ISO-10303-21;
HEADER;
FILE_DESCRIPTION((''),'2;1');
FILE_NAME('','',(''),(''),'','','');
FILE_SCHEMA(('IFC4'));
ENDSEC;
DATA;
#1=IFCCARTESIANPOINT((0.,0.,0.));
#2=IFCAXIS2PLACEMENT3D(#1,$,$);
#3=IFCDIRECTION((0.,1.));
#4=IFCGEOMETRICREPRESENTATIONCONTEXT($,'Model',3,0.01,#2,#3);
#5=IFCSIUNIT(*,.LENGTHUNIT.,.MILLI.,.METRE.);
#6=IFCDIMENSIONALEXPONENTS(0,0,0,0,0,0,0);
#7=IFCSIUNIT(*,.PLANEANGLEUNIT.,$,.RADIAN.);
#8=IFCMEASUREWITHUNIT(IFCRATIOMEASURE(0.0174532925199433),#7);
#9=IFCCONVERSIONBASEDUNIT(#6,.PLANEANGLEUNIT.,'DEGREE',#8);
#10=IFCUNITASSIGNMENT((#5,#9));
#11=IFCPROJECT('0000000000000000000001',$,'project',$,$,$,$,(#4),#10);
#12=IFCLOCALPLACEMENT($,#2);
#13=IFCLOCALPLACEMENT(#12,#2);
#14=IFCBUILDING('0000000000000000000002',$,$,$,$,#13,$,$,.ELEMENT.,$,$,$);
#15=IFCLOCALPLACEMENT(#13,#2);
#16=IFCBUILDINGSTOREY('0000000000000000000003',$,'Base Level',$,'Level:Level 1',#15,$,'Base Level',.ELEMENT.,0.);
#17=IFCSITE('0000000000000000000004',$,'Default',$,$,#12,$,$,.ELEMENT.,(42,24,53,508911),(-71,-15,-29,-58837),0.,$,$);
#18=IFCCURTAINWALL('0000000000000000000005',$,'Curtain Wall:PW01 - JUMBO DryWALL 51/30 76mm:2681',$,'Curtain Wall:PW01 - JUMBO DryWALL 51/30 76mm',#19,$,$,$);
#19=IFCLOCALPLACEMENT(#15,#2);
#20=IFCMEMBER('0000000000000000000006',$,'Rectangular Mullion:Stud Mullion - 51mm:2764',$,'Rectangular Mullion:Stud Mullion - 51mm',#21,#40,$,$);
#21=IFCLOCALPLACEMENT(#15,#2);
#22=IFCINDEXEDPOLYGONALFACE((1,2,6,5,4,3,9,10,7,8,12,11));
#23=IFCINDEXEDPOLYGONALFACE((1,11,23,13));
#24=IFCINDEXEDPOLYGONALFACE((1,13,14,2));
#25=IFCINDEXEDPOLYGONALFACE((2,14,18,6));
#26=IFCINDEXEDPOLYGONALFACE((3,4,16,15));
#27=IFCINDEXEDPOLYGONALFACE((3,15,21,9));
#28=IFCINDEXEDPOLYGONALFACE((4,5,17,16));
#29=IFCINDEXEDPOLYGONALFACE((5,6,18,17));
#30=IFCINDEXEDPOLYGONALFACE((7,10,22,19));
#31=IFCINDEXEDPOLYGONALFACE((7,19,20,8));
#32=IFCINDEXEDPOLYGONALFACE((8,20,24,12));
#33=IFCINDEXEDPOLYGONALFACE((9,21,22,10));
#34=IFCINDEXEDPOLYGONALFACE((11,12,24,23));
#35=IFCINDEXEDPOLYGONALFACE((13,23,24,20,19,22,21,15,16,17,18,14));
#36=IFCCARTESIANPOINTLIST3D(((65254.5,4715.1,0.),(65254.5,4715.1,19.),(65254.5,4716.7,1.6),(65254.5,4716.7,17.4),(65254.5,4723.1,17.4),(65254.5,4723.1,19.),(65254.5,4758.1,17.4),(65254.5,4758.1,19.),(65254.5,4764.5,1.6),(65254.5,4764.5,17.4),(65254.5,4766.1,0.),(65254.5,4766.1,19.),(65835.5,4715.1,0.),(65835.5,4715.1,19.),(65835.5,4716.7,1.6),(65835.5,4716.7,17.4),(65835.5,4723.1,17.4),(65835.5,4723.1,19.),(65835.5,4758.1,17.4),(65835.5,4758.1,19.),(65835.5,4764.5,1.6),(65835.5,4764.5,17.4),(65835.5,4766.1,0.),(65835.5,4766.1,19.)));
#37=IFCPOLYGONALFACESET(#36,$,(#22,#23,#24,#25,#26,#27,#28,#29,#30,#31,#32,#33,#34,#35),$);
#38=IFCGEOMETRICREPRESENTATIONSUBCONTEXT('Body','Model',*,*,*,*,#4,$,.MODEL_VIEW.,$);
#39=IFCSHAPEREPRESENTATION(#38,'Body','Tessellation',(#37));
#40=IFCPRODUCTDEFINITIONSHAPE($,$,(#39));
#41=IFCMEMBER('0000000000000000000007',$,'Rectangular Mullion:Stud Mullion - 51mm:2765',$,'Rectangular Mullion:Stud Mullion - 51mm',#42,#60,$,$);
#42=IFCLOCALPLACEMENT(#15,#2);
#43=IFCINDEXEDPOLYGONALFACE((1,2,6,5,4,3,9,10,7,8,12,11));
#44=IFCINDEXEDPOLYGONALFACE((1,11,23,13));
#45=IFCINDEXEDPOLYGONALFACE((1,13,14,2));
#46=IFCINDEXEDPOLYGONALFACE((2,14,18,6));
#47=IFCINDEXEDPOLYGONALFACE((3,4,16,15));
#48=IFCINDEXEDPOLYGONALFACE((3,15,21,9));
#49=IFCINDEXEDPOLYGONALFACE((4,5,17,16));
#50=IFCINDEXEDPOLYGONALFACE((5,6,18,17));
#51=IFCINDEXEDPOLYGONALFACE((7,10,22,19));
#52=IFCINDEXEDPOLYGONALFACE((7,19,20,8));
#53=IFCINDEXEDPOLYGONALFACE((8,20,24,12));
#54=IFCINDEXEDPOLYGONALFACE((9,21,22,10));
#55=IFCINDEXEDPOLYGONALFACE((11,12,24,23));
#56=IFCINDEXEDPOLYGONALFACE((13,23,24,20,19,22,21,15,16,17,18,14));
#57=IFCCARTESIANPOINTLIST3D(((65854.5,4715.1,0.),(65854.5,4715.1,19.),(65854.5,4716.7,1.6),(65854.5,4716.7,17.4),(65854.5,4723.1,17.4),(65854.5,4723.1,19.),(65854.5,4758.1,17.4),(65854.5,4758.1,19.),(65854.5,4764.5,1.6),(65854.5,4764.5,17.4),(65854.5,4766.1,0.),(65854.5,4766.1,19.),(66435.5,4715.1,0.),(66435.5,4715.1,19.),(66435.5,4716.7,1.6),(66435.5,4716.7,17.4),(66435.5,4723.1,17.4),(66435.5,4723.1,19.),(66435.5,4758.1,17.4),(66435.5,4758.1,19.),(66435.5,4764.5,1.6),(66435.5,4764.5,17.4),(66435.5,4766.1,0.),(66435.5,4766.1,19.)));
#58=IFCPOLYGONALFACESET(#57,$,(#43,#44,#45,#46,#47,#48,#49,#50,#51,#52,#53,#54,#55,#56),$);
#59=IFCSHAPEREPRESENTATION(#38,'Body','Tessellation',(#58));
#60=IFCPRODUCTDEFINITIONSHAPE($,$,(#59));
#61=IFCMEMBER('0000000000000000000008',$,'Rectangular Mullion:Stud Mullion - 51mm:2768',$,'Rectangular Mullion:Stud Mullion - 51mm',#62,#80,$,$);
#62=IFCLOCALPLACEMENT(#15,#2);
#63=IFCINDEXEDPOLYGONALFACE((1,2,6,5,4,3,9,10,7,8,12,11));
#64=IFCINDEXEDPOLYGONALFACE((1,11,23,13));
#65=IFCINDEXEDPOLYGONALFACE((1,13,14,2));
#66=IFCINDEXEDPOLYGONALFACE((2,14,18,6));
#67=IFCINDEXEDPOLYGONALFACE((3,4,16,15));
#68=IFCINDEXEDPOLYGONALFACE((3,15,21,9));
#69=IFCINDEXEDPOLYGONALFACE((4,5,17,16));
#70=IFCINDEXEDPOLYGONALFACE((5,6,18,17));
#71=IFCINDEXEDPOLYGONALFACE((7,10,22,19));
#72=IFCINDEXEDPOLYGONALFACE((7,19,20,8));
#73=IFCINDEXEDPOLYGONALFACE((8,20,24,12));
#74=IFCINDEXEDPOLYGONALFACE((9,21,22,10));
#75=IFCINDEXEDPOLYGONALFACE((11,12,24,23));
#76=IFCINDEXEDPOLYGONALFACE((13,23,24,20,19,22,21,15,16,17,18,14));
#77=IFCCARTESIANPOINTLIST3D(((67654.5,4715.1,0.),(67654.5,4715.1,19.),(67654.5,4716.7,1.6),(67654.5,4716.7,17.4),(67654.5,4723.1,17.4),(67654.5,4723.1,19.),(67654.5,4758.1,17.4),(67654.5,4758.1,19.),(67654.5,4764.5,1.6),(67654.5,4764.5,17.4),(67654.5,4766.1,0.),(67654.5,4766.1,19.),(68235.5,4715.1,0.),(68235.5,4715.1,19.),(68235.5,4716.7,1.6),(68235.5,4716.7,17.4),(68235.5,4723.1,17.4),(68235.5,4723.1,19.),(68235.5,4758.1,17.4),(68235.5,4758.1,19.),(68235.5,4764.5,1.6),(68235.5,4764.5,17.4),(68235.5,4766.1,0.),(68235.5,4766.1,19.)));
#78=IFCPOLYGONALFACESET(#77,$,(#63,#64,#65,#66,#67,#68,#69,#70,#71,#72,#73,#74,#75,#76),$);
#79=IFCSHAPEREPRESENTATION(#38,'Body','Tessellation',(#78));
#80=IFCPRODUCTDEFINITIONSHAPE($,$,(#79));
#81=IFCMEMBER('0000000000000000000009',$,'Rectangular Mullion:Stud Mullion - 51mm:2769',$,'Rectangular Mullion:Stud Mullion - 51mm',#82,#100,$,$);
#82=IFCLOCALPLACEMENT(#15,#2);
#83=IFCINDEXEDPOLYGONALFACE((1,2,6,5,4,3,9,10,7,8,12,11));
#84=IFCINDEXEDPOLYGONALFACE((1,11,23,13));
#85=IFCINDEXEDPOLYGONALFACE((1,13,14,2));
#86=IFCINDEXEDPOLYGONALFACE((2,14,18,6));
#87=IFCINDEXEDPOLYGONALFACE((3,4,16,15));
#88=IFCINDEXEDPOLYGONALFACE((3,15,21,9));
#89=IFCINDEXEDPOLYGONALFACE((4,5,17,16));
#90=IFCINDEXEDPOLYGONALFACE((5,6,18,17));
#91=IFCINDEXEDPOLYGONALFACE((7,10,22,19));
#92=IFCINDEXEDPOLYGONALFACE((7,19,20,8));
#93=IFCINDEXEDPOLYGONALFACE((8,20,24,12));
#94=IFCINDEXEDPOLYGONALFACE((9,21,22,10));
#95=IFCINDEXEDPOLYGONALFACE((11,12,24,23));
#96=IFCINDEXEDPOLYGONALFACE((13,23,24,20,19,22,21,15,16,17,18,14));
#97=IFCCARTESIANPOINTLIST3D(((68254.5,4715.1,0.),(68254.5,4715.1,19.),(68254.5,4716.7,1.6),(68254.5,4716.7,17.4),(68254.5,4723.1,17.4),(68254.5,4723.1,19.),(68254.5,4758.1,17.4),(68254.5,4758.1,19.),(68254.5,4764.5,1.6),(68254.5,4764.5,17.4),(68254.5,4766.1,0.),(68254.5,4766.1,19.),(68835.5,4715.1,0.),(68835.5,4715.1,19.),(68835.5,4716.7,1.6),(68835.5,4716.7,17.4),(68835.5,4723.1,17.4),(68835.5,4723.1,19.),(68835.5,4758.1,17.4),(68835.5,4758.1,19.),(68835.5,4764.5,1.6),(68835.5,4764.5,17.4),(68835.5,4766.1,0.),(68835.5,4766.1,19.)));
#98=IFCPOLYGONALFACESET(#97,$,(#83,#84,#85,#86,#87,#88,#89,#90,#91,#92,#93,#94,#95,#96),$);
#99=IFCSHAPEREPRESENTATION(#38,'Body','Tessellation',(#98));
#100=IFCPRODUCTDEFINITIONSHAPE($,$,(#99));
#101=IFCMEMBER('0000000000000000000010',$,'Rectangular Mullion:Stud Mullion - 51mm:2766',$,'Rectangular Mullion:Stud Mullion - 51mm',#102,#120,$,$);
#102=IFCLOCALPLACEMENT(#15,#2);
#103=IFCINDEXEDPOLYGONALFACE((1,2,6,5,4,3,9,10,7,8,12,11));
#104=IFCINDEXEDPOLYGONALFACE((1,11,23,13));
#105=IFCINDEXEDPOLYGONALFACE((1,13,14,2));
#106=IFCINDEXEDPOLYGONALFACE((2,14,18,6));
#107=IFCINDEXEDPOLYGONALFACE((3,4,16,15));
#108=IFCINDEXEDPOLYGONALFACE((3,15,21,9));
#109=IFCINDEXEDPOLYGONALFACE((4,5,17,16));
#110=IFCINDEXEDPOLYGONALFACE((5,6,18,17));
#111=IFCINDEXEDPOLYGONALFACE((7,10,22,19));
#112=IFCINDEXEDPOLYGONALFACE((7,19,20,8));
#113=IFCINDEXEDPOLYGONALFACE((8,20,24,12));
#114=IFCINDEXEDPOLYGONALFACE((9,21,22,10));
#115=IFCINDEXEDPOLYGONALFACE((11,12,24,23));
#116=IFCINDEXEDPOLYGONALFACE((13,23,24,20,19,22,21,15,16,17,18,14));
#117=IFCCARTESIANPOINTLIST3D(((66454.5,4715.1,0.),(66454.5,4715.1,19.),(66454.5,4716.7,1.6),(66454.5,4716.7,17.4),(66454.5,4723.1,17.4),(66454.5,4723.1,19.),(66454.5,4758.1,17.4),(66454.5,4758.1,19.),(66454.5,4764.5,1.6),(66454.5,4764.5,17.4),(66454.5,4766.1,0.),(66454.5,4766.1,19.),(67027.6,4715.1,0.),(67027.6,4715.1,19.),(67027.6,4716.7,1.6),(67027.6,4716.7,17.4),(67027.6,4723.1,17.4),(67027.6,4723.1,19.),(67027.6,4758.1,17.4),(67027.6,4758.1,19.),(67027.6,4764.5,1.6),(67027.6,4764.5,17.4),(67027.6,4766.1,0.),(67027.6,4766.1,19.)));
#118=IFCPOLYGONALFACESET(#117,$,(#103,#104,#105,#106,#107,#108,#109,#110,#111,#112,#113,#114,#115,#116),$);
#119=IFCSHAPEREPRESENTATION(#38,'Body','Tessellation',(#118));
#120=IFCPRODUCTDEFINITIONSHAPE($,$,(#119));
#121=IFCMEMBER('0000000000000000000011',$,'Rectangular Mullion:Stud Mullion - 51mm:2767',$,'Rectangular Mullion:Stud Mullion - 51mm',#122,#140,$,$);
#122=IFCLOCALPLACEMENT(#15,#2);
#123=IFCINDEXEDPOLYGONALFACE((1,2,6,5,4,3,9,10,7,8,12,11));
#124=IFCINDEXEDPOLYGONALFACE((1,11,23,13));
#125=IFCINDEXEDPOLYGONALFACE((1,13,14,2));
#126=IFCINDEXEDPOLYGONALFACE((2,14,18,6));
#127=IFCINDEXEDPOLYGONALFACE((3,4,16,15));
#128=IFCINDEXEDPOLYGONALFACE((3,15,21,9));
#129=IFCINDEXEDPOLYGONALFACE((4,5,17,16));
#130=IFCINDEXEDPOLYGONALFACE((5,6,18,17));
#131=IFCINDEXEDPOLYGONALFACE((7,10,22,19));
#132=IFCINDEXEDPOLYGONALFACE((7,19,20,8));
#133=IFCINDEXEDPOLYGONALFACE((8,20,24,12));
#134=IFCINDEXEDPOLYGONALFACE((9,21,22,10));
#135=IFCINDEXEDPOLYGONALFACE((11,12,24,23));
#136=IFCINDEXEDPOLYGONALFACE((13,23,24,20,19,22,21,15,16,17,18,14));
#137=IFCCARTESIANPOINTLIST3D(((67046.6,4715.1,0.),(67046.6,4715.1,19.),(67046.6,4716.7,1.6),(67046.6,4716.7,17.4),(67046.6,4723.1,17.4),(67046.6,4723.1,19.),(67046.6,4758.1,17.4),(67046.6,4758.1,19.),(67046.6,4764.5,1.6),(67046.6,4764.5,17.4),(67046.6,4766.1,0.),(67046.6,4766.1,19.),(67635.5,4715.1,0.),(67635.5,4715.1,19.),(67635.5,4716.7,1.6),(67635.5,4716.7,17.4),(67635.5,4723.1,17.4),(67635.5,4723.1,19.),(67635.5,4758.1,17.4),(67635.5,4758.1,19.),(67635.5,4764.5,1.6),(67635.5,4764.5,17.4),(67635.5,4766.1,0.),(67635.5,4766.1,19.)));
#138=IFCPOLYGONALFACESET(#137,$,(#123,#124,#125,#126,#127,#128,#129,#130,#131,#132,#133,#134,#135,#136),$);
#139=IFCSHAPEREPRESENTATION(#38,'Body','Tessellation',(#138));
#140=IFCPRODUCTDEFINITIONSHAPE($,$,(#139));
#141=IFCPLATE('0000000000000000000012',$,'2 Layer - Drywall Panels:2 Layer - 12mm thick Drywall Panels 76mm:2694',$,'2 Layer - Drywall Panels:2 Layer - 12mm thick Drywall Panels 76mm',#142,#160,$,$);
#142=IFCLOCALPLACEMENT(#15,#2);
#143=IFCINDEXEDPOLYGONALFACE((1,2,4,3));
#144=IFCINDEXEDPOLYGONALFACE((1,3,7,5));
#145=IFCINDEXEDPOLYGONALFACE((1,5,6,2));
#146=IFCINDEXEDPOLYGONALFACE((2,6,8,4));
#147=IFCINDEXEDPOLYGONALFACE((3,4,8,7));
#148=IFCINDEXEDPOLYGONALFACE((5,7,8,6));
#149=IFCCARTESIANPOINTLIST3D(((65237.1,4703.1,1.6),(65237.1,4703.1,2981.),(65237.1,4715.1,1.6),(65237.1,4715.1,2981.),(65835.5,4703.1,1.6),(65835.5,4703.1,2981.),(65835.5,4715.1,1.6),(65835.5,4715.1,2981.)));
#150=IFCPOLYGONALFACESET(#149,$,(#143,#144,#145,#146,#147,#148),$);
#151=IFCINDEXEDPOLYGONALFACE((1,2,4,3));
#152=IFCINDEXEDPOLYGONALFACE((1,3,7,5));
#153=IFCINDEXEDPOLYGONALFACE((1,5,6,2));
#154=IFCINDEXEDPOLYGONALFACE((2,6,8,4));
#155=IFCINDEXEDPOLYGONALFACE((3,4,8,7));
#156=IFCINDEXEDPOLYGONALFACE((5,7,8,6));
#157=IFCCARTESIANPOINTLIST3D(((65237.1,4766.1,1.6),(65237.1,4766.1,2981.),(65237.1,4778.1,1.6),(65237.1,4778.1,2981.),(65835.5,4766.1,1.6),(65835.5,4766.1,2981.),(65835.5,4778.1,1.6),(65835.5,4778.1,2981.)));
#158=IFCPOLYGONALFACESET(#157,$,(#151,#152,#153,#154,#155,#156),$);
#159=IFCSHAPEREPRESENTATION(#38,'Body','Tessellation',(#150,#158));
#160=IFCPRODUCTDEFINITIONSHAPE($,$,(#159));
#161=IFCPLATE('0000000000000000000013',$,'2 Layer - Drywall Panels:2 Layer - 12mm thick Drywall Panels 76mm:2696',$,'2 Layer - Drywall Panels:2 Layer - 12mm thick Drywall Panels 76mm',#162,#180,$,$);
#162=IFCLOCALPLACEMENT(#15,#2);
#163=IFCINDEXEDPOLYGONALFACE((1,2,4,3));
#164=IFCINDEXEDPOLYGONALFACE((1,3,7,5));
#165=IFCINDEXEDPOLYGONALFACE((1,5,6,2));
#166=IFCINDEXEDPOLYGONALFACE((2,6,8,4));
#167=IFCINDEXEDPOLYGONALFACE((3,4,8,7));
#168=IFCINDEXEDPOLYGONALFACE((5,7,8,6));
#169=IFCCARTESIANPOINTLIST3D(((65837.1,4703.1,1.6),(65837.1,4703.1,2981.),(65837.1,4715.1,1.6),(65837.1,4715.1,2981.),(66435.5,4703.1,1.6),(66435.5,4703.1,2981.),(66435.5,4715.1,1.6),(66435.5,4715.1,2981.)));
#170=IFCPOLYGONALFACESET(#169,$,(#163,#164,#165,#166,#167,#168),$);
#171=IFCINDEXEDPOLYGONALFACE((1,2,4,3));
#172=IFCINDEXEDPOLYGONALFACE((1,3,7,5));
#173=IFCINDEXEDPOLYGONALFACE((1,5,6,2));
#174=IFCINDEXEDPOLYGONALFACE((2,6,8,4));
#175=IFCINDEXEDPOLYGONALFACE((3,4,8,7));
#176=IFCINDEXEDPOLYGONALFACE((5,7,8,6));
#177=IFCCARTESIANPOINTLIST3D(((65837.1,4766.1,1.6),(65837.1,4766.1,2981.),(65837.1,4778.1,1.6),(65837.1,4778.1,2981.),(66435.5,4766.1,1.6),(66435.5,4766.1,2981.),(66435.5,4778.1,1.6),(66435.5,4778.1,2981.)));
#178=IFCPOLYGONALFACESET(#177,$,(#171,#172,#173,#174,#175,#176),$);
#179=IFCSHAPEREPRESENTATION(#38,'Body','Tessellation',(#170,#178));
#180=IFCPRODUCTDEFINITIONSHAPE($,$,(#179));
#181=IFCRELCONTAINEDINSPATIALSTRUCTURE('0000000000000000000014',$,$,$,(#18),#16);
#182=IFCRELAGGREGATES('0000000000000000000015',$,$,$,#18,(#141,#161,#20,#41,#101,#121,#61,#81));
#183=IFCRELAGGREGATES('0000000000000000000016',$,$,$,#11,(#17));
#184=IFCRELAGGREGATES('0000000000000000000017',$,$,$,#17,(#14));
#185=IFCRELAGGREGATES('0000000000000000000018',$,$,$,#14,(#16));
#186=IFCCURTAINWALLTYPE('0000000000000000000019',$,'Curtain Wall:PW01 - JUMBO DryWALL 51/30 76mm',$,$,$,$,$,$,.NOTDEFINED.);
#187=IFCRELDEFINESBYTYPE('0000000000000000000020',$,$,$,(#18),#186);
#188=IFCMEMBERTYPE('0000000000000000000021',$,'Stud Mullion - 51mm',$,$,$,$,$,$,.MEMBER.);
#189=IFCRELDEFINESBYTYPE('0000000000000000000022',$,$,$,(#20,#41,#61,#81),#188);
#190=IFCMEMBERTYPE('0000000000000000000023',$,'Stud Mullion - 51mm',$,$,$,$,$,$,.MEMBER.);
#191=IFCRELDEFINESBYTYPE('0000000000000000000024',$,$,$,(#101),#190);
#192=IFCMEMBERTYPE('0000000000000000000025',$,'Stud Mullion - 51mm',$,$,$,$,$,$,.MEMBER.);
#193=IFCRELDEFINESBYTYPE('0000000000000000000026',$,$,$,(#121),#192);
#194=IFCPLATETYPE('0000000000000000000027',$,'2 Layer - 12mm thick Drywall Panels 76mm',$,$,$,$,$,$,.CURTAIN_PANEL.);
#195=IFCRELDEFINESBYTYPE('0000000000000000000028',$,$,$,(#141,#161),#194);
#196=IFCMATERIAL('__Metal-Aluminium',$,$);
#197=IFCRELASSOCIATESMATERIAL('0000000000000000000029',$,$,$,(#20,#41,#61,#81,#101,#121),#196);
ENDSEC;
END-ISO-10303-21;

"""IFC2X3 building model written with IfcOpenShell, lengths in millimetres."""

from ifc_helpers import new_model, entity, si_unit, converted_unit, direction, frame, frame_2d, origin, origin_2d_with_axis, place, context, subcontext, project, spatial, polyline, rectangle, outline, extrude, source, transform, mapped, material, type_object, type_shapes, element, aggregate, save


model = new_model("IFC2X3")

# Units and contexts
model_context = context("Model", 3, precision=0.01, world=origin(), true_north=direction((0.0, 1.0)))
body_context = subcontext(model_context, "Body", "Model", "MODEL_VIEW")
ifc_project = project(units=[si_unit("LENGTHUNIT", "METRE", prefix="MILLI"), converted_unit("PLANEANGLEUNIT", "DEGREE", entity("IfcRatioMeasure", 0.0174532925199433), si_unit("PLANEANGLEUNIT", "RADIAN"), dimensions=[0, 0, 0, 0, 0, 0, 0])], contexts=[model_context])

# Site, building, storey
site_placement = place(None, origin())
site = spatial("IfcSite", under=ifc_project, at=site_placement, Name="Default", CompositionType="ELEMENT", RefLatitude=(42, 24, 53, 508911), RefLongitude=(-71, -15, -29, -58837), RefElevation=0.0)
building_placement = place(site_placement, origin())
building = spatial("IfcBuilding", under=site, at=building_placement, CompositionType="ELEMENT")
storey_placement = place(building_placement, origin())
storey = spatial("IfcBuildingStorey", under=building, at=storey_placement, Name="Base Level", ObjectType="Level:Level 1", LongName="Base Level", CompositionType="ELEMENT", Elevation=0.0)

# Curtain wall, members, plates
curtain_wall_type = type_object("IfcCurtainWallType", Name="Curtain Wall:PW01 - JUMBO DryWALL 51/30 76mm", PredefinedType="NOTDEFINED")
curtain_wall_placement = place(building_placement, origin())
curtain_wall = element("IfcCurtainWall", 1, at=curtain_wall_placement, inside=storey, type_object=curtain_wall_type, Name="Curtain Wall:PW01 - JUMBO DryWALL 51/30 76mm:2681", ObjectType="Curtain Wall:PW01 - JUMBO DryWALL 51/30 76mm")
ifc_material = material(Name="__Metal-Aluminium")
member_type_1 = type_object("IfcMemberType", Name="Stud Mullion - 51mm", PredefinedType="MEMBER")
shared_shape_1 = source(origin(), body_context, "Body", "SweptSolid", [
    extrude(outline(polyline([(17.5, -6.6), (25.5, -6.6), (25.5, 12.4), (-25.5, 12.4), (-25.5, -6.6), (-17.5, -6.6), (-17.5, -5.0), (-23.9, -5.0), (-23.9, 10.8), (23.9, 10.8), (23.9, -5.0), (17.5, -5.0), (17.5, -6.6)])), frame((-12.4, 0.0, -581.0), z_axis=(0.0, 0.0, 1.0), x_axis=(0.0, -1.0, 0.0)), (0.0, 0.0, 1.0), 581.0),
])
type_shapes(member_type_1, [shared_shape_1])
member_1_placement = place(building_placement, frame((65254.5, 4740.6, 0.0), z_axis=(-1.0, 0.0, 0.0), x_axis=(0.0, 0.0, -1.0)))
member_1 = element("IfcMember", 2, at=member_1_placement, type_object=member_type_1, material=ifc_material, Name="Rectangular Mullion:Stud Mullion - 51mm:2764", ObjectType="Rectangular Mullion:Stud Mullion - 51mm", context=body_context, shape_type="MappedRepresentation", body=[
    mapped(shared_shape_1, transform((0.0, 0.0, 0.0), scale=1.0)),
])
member_2_placement = place(building_placement, frame((65854.5, 4740.6, 0.0), z_axis=(-1.0, 0.0, 0.0), x_axis=(0.0, 0.0, -1.0)))
member_2 = element("IfcMember", 3, at=member_2_placement, type_object=member_type_1, material=ifc_material, Name="Rectangular Mullion:Stud Mullion - 51mm:2765", ObjectType="Rectangular Mullion:Stud Mullion - 51mm", context=body_context, shape_type="MappedRepresentation", body=[
    mapped(shared_shape_1, transform((0.0, 0.0, 0.0), scale=1.0)),
])
member_3_placement = place(building_placement, frame((67654.5, 4740.6, 0.0), z_axis=(-1.0, 0.0, 0.0), x_axis=(0.0, 0.0, -1.0)))
member_3 = element("IfcMember", 4, at=member_3_placement, type_object=member_type_1, material=ifc_material, Name="Rectangular Mullion:Stud Mullion - 51mm:2768", ObjectType="Rectangular Mullion:Stud Mullion - 51mm", context=body_context, shape_type="MappedRepresentation", body=[
    mapped(shared_shape_1, transform((0.0, 0.0, 0.0), scale=1.0)),
])
member_4_placement = place(building_placement, frame((68254.5, 4740.6, 0.0), z_axis=(-1.0, 0.0, 0.0), x_axis=(0.0, 0.0, -1.0)))
member_4 = element("IfcMember", 5, at=member_4_placement, type_object=member_type_1, material=ifc_material, Name="Rectangular Mullion:Stud Mullion - 51mm:2769", ObjectType="Rectangular Mullion:Stud Mullion - 51mm", context=body_context, shape_type="MappedRepresentation", body=[
    mapped(shared_shape_1, transform((0.0, 0.0, 0.0), scale=1.0)),
])
member_type_2 = type_object("IfcMemberType", Name="Stud Mullion - 51mm", PredefinedType="MEMBER")
shared_shape_2 = source(origin(), body_context, "Body", "SweptSolid", [
    extrude(outline(polyline([(17.5, -6.6), (25.5, -6.6), (25.5, 12.4), (-25.5, 12.4), (-25.5, -6.6), (-17.5, -6.6), (-17.5, -5.0), (-23.9, -5.0), (-23.9, 10.8), (23.9, 10.8), (23.9, -5.0), (17.5, -5.0), (17.5, -6.6)])), frame((-12.4, 0.0, -573.1), z_axis=(0.0, 0.0, 1.0), x_axis=(0.0, -1.0, 0.0)), (0.0, 0.0, 1.0), 573.1),
])
type_shapes(member_type_2, [shared_shape_2])
member_5_placement = place(building_placement, frame((66454.5, 4740.6, 0.0), z_axis=(-1.0, 0.0, 0.0), x_axis=(0.0, 0.0, -1.0)))
member_5 = element("IfcMember", 6, at=member_5_placement, type_object=member_type_2, material=ifc_material, Name="Rectangular Mullion:Stud Mullion - 51mm:2766", ObjectType="Rectangular Mullion:Stud Mullion - 51mm", context=body_context, shape_type="MappedRepresentation", body=[
    mapped(shared_shape_2, transform((0.0, 0.0, 0.0), scale=1.0)),
])
member_type_3 = type_object("IfcMemberType", Name="Stud Mullion - 51mm", PredefinedType="MEMBER")
shared_shape_3 = source(origin(), body_context, "Body", "SweptSolid", [
    extrude(outline(polyline([(17.5, -6.6), (25.5, -6.6), (25.5, 12.4), (-25.5, 12.4), (-25.5, -6.6), (-17.5, -6.6), (-17.5, -5.0), (-23.9, -5.0), (-23.9, 10.8), (23.9, 10.8), (23.9, -5.0), (17.5, -5.0), (17.5, -6.6)])), frame((-12.4, 0.0, -588.9), z_axis=(0.0, 0.0, 1.0), x_axis=(0.0, -1.0, 0.0)), (0.0, 0.0, 1.0), 588.9),
])
type_shapes(member_type_3, [shared_shape_3])
member_6_placement = place(building_placement, frame((67046.6, 4740.6, 0.0), z_axis=(-1.0, 0.0, 0.0), x_axis=(0.0, 0.0, -1.0)))
member_6 = element("IfcMember", 7, at=member_6_placement, type_object=member_type_3, material=ifc_material, Name="Rectangular Mullion:Stud Mullion - 51mm:2767", ObjectType="Rectangular Mullion:Stud Mullion - 51mm", context=body_context, shape_type="MappedRepresentation", body=[
    mapped(shared_shape_3, transform((0.0, 0.0, 0.0), scale=1.0)),
])
plate_type_1 = type_object("IfcPlateType", Name="2 Layer - 12mm thick Drywall Panels 76mm", PredefinedType="CURTAIN_PANEL")
shared_shape_4 = source(origin(), body_context, "Body", "SweptSolid", [
    extrude(rectangle(XDim=598.4, YDim=12.0, at=origin_2d_with_axis()), frame((0.0, -31.5, 0.0), z_axis=(0.0, 0.0, 1.0), x_axis=(-1.0, 0.0, 0.0)), (0.0, 0.0, 1.0), 2979.4),
    extrude(rectangle(XDim=12.0, YDim=598.4, at=frame_2d((0.0, 0.0), x_axis=(1.0, 0.0))), frame((0.0, 31.5, 0.0), z_axis=(0.0, 0.0, 1.0), x_axis=(0.0, 1.0, 0.0)), (0.0, 0.0, 1.0), 2979.4),
])
type_shapes(plate_type_1, [shared_shape_4])
plate_1_placement = place(curtain_wall_placement, frame((65536.3, 4740.6, 1.6)))
plate_1 = element("IfcPlate", 8, at=plate_1_placement, type_object=plate_type_1, Name="2 Layer - Drywall Panels:2 Layer - 12mm thick Drywall Panels 76mm:2694", ObjectType="2 Layer - Drywall Panels:2 Layer - 12mm thick Drywall Panels 76mm", context=body_context, shape_type="MappedRepresentation", body=[
    mapped(shared_shape_4, transform((0.0, 0.0, 0.0), scale=1.0)),
])
plate_2_placement = place(curtain_wall_placement, frame((66136.3, 4740.6, 1.6)))
plate_2 = element("IfcPlate", 9, at=plate_2_placement, type_object=plate_type_1, Name="2 Layer - Drywall Panels:2 Layer - 12mm thick Drywall Panels 76mm:2696", ObjectType="2 Layer - Drywall Panels:2 Layer - 12mm thick Drywall Panels 76mm", context=body_context, shape_type="MappedRepresentation", body=[
    mapped(shared_shape_4, transform((0.0, 0.0, 0.0), scale=1.0)),
])
aggregate(curtain_wall, [plate_1, plate_2, member_1, member_2, member_5, member_6, member_3, member_4])

save(model, "model.ifc")
